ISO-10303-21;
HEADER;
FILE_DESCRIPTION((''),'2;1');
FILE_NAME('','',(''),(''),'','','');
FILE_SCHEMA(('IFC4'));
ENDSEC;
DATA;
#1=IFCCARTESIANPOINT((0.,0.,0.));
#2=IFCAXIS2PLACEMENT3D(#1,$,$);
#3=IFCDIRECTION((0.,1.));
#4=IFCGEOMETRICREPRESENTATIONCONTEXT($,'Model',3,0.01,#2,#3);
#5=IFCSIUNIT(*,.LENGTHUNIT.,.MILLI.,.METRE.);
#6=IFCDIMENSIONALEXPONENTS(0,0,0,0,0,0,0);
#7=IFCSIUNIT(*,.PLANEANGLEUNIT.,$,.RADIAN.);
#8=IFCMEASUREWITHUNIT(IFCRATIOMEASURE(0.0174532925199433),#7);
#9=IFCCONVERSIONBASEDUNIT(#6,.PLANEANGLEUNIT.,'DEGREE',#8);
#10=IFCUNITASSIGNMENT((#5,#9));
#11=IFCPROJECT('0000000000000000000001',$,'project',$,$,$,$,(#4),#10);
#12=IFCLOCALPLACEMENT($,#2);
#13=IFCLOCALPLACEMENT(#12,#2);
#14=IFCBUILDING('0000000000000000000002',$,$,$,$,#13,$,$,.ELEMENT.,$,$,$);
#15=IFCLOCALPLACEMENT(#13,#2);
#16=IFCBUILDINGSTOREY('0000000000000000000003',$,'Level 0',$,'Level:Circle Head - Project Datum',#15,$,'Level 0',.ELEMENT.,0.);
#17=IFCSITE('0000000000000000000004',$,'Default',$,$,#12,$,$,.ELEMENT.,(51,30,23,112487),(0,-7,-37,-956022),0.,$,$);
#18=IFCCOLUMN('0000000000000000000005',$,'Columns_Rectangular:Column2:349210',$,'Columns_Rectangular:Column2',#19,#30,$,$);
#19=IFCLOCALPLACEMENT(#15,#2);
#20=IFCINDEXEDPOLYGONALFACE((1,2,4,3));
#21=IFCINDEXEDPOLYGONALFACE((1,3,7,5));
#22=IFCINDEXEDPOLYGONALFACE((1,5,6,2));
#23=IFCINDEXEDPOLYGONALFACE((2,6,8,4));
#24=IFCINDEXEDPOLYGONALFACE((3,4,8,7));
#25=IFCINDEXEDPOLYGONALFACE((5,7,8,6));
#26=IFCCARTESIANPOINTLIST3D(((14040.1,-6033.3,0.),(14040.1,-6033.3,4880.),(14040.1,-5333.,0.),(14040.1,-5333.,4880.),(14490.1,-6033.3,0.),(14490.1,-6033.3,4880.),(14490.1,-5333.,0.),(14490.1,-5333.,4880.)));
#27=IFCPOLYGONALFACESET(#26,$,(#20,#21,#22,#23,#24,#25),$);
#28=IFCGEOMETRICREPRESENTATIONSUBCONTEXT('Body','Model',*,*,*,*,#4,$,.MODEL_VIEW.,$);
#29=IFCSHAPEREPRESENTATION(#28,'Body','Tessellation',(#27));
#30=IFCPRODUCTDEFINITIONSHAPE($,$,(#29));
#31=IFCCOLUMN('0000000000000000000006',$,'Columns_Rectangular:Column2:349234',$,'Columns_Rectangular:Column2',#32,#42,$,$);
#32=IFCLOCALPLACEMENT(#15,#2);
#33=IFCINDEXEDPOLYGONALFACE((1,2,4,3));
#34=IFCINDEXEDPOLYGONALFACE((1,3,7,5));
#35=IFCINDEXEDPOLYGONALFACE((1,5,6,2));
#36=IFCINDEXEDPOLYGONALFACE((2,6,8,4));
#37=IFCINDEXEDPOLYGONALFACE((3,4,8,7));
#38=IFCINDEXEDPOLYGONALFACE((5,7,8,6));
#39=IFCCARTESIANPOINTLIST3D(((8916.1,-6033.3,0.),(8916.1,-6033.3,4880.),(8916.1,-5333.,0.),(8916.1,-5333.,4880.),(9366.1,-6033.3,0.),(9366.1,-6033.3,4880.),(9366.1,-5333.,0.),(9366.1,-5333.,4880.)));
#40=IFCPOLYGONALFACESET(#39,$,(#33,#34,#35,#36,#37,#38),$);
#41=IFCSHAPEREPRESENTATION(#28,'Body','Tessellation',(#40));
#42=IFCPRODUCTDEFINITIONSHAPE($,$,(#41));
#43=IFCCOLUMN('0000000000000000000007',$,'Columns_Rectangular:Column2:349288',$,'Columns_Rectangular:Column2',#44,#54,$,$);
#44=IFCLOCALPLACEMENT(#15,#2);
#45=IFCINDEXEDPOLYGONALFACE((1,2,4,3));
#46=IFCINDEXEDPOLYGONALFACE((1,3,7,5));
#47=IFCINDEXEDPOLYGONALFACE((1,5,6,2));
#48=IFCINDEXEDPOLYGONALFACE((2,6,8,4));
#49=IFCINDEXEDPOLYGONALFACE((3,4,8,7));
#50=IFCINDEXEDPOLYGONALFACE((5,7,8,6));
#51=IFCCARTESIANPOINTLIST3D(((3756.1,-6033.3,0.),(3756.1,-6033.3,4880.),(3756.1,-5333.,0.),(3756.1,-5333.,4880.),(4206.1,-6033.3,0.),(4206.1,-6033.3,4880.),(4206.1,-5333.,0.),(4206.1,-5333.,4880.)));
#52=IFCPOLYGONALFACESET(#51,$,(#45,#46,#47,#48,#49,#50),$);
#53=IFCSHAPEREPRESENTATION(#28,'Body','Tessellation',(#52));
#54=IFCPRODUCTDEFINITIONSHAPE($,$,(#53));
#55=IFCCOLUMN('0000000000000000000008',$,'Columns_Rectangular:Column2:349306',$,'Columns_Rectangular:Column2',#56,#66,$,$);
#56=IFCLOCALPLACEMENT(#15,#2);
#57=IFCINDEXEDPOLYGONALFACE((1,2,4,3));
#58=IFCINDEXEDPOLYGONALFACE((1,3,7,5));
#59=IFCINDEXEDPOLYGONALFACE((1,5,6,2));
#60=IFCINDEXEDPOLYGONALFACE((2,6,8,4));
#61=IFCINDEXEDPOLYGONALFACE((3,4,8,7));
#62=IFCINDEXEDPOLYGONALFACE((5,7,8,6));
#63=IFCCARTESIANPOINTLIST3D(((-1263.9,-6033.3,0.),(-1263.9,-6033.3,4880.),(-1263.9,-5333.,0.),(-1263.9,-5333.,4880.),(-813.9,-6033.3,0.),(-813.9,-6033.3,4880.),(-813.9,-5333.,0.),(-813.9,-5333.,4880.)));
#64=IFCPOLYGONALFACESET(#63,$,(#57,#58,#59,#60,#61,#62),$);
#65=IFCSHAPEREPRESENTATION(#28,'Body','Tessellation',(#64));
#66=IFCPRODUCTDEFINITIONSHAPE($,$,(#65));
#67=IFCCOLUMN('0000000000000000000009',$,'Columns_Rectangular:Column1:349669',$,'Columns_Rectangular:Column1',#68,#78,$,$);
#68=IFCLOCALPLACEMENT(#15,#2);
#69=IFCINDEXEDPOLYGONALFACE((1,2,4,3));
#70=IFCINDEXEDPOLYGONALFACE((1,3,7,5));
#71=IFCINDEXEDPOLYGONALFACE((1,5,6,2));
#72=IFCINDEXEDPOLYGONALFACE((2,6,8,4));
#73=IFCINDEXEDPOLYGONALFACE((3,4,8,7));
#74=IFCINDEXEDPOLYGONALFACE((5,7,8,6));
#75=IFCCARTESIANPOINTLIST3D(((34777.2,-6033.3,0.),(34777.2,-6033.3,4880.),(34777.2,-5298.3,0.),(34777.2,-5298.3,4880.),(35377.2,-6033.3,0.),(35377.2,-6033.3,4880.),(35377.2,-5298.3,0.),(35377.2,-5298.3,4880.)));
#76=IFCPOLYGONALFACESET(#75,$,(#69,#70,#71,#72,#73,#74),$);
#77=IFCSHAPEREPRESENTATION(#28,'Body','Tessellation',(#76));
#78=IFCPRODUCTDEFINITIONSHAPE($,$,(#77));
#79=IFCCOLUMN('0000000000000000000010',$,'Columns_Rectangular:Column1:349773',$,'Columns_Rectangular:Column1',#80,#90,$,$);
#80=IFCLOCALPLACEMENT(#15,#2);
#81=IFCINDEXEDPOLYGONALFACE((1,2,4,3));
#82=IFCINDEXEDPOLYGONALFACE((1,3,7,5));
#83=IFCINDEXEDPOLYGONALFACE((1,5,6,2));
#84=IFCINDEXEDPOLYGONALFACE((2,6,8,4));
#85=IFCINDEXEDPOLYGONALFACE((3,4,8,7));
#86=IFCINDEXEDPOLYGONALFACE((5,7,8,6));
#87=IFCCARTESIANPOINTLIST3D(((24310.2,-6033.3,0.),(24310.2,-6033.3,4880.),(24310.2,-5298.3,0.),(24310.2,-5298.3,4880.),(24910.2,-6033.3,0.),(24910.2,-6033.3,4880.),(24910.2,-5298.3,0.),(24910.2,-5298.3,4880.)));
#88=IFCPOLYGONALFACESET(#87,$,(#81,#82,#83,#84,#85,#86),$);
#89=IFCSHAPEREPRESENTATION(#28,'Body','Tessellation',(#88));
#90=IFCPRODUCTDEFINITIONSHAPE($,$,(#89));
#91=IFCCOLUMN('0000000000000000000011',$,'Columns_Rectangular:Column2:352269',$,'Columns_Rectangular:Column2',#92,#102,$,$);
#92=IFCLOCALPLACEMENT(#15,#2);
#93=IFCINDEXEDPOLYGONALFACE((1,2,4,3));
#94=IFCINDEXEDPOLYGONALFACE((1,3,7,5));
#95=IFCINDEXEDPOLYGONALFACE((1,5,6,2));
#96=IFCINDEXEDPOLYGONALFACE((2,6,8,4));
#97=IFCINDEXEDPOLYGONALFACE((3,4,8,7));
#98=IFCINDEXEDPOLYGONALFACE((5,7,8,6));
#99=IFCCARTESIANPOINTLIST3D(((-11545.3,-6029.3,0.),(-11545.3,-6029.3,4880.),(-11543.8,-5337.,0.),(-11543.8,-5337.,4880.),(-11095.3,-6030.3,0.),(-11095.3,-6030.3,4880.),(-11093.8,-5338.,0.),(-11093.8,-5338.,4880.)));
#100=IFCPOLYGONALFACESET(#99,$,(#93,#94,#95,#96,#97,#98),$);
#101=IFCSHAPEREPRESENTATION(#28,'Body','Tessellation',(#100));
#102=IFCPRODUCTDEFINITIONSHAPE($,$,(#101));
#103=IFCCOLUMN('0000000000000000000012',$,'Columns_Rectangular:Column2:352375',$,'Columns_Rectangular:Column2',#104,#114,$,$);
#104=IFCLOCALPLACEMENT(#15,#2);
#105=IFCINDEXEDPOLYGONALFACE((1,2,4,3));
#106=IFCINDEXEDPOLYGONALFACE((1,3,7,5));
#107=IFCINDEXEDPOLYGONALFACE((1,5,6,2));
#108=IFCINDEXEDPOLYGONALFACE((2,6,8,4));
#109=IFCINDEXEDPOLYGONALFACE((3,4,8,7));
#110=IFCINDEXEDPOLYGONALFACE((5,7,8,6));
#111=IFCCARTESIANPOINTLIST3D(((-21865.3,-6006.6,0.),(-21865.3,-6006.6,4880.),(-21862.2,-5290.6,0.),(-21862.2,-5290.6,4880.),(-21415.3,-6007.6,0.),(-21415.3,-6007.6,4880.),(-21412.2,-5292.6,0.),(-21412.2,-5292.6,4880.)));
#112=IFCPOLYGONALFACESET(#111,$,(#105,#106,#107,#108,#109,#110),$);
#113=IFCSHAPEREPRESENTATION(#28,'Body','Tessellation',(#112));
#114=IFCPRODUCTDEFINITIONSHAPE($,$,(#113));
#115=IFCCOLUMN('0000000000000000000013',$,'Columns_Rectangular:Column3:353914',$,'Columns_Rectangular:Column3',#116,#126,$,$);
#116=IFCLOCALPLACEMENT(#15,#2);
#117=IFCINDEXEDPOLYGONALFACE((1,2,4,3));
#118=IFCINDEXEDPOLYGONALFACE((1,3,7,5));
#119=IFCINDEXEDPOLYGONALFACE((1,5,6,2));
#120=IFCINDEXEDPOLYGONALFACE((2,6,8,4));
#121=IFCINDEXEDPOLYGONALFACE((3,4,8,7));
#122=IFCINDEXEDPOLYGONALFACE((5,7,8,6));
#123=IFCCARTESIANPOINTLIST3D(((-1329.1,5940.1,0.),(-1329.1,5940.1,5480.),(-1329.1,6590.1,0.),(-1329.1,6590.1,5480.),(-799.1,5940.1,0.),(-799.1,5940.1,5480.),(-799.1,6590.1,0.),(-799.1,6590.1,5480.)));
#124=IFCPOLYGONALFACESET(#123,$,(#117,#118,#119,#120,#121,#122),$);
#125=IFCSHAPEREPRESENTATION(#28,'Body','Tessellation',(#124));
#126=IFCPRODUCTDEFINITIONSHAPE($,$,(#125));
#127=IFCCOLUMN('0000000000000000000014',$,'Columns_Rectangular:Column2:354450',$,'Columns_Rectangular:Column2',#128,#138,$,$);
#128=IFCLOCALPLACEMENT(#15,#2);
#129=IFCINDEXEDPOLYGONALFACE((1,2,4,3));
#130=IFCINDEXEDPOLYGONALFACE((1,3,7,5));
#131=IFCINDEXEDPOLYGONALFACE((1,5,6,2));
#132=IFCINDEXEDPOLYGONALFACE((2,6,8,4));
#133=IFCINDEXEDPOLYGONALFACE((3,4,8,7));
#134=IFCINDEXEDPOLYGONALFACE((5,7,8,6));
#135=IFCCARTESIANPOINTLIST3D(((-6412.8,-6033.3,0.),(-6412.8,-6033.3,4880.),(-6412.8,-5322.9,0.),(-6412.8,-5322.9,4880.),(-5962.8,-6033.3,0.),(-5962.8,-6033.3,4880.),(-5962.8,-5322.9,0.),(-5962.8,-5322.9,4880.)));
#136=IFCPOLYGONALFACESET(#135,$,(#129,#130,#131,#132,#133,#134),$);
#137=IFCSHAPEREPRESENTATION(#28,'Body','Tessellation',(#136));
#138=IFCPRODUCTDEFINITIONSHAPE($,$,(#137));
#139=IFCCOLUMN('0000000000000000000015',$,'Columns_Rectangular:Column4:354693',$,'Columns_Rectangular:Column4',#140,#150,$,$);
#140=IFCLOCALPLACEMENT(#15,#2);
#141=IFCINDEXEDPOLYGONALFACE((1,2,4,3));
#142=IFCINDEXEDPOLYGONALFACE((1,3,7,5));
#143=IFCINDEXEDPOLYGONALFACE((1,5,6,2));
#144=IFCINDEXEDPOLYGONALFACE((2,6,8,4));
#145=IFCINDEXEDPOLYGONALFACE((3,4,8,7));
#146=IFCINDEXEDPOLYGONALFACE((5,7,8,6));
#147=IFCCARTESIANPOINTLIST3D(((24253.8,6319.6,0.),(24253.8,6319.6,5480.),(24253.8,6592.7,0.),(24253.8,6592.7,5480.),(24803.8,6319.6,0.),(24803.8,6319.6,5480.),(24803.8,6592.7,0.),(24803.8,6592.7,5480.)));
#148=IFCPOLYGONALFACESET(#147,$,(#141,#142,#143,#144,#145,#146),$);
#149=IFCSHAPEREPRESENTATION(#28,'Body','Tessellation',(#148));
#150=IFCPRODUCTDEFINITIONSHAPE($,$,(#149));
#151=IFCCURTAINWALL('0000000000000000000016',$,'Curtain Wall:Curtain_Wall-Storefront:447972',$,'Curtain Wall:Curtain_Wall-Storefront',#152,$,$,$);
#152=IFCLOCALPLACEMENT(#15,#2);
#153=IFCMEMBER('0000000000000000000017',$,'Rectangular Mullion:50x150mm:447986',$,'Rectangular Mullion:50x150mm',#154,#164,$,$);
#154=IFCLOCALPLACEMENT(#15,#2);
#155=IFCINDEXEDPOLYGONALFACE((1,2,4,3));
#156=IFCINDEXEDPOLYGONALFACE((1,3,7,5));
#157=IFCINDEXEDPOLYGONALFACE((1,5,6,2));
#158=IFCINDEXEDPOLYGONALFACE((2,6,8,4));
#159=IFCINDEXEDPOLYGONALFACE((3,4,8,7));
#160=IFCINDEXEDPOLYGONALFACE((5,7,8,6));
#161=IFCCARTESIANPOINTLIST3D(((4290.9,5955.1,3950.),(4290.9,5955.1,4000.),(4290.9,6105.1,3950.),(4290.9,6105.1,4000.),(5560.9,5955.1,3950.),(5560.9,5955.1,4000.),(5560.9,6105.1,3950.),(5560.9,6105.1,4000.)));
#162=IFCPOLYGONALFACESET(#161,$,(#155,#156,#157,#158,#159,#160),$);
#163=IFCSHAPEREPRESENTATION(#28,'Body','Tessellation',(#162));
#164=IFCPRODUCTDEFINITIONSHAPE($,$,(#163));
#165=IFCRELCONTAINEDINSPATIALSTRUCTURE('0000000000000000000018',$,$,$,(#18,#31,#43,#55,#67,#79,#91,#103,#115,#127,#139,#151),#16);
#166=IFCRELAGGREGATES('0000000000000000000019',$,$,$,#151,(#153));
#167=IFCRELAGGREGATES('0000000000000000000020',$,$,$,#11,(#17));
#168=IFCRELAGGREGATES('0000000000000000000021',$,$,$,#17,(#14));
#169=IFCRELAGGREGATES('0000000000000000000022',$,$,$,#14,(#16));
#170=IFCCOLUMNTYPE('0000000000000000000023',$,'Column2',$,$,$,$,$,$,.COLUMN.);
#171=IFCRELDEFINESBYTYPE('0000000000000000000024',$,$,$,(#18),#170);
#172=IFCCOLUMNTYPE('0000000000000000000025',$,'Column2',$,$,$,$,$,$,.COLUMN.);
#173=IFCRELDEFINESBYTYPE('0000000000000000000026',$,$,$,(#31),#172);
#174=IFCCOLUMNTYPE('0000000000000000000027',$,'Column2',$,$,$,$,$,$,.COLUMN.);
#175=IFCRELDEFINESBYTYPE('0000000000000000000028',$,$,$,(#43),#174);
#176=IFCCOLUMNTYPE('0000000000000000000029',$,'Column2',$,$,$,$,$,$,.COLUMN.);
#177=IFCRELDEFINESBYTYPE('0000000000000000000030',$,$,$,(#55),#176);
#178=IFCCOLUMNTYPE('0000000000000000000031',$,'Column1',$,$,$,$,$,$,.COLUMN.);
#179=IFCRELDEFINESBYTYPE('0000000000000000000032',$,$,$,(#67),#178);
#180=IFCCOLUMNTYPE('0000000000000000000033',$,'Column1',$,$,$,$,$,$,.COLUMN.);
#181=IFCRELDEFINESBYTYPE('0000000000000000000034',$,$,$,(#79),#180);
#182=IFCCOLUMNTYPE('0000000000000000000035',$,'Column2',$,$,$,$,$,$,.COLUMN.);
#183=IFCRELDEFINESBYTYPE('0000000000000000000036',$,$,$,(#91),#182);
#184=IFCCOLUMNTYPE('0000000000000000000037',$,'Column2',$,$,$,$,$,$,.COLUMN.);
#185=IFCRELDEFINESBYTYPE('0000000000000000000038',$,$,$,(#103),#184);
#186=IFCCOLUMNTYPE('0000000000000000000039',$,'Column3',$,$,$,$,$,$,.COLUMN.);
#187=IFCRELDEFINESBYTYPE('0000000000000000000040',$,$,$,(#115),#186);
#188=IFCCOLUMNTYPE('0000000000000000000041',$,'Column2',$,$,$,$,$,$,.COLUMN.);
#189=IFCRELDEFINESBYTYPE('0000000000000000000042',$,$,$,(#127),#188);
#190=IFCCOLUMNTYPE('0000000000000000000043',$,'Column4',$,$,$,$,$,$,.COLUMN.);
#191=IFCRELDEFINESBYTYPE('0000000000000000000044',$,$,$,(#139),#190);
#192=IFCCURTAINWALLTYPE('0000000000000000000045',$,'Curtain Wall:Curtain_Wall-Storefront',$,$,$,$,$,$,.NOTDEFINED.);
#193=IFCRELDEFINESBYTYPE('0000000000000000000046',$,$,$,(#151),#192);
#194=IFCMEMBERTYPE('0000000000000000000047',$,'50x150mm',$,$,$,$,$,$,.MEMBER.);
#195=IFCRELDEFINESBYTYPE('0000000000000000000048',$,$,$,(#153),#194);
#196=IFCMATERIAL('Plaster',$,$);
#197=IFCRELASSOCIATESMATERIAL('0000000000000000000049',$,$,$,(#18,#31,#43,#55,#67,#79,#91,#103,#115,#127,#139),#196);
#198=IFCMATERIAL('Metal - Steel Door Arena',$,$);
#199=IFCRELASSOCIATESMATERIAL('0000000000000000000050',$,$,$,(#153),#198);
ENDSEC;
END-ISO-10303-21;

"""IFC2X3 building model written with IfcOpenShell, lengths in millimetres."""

from ifc_helpers import new_model, entity, si_unit, converted_unit, direction, frame, frame_2d, origin, origin_2d_with_axis, place, context, subcontext, project, spatial, polyline, rectangle, outline, extrude, source, transform, mapped, material, type_object, type_shapes, element, aggregate, save


model = new_model("IFC2X3")

# Units and contexts
model_context = context("Model", 3, precision=0.01, world=origin(), true_north=direction((0.0, 1.0)))
body_context = subcontext(model_context, "Body", "Model", "MODEL_VIEW")
ifc_project = project(units=[si_unit("LENGTHUNIT", "METRE", prefix="MILLI"), converted_unit("PLANEANGLEUNIT", "DEGREE", entity("IfcRatioMeasure", 0.0174532925199433), si_unit("PLANEANGLEUNIT", "RADIAN"), dimensions=[0, 0, 0, 0, 0, 0, 0])], contexts=[model_context])

# Site, building, storey
site_placement = place(None, origin())
site = spatial("IfcSite", under=ifc_project, at=site_placement, Name="Default", CompositionType="ELEMENT", RefLatitude=(51, 30, 23, 112487), RefLongitude=(0, -7, -37, -956022), RefElevation=0.0)
building_placement = place(site_placement, origin())
building = spatial("IfcBuilding", under=site, at=building_placement, CompositionType="ELEMENT")
storey_placement = place(building_placement, origin())
storey = spatial("IfcBuildingStorey", under=building, at=storey_placement, Name="Level 0", ObjectType="Level:Circle Head - Project Datum", LongName="Level 0", CompositionType="ELEMENT", Elevation=0.0)

# Columns
ifc_material_1 = material(Name="Plaster")
column_type_1 = type_object("IfcColumnType", Name="Column2", PredefinedType="COLUMN")
shared_shape_1 = source(origin(), body_context, "Body", "SweptSolid", [
    extrude(rectangle(XDim=700.3, YDim=450.0, at=frame_2d((0.0, 0.0), x_axis=(1.0, 0.0))), frame((14265.1, -5683.1, 0.0), z_axis=(0.0, 0.0, 1.0), x_axis=(0.0, -1.0, 0.0)), (0.0, 0.0, 1.0), 4880.0),
])
type_shapes(column_type_1, [shared_shape_1])
column_1_placement = place(storey_placement, origin())
element("IfcColumn", 1, at=column_1_placement, inside=storey, type_object=column_type_1, material=ifc_material_1, Name="Columns_Rectangular:Column2:349210", ObjectType="Columns_Rectangular:Column2", context=body_context, shape_type="MappedRepresentation", body=[
    mapped(shared_shape_1, transform((0.0, 0.0, 0.0), scale=1.0)),
])
column_type_2 = type_object("IfcColumnType", Name="Column2", PredefinedType="COLUMN")
shared_shape_2 = source(origin(), body_context, "Body", "SweptSolid", [
    extrude(rectangle(XDim=700.3, YDim=450.0, at=frame_2d((0.0, 0.0), x_axis=(1.0, 0.0))), frame((9141.1, -5683.1, 0.0), z_axis=(0.0, 0.0, 1.0), x_axis=(0.0, -1.0, 0.0)), (0.0, 0.0, 1.0), 4880.0),
])
type_shapes(column_type_2, [shared_shape_2])
column_2_placement = place(storey_placement, origin())
element("IfcColumn", 2, at=column_2_placement, inside=storey, type_object=column_type_2, material=ifc_material_1, Name="Columns_Rectangular:Column2:349234", ObjectType="Columns_Rectangular:Column2", context=body_context, shape_type="MappedRepresentation", body=[
    mapped(shared_shape_2, transform((0.0, 0.0, 0.0), scale=1.0)),
])
column_type_3 = type_object("IfcColumnType", Name="Column2", PredefinedType="COLUMN")
shared_shape_3 = source(origin(), body_context, "Body", "SweptSolid", [
    extrude(rectangle(XDim=700.3, YDim=450.0, at=frame_2d((0.0, 0.0), x_axis=(1.0, 0.0))), frame((3981.1, -5683.1, 0.0), z_axis=(0.0, 0.0, 1.0), x_axis=(0.0, -1.0, 0.0)), (0.0, 0.0, 1.0), 4880.0),
])
type_shapes(column_type_3, [shared_shape_3])
column_3_placement = place(storey_placement, origin())
element("IfcColumn", 3, at=column_3_placement, inside=storey, type_object=column_type_3, material=ifc_material_1, Name="Columns_Rectangular:Column2:349288", ObjectType="Columns_Rectangular:Column2", context=body_context, shape_type="MappedRepresentation", body=[
    mapped(shared_shape_3, transform((0.0, 0.0, 0.0), scale=1.0)),
])
column_type_4 = type_object("IfcColumnType", Name="Column2", PredefinedType="COLUMN")
shared_shape_4 = source(origin(), body_context, "Body", "SweptSolid", [
    extrude(rectangle(XDim=700.3, YDim=450.0, at=frame_2d((0.0, 0.0), x_axis=(1.0, 0.0))), frame((-1038.9, -5683.1, 0.0), z_axis=(0.0, 0.0, 1.0), x_axis=(0.0, -1.0, 0.0)), (0.0, 0.0, 1.0), 4880.0),
])
type_shapes(column_type_4, [shared_shape_4])
column_4_placement = place(storey_placement, origin())
element("IfcColumn", 4, at=column_4_placement, inside=storey, type_object=column_type_4, material=ifc_material_1, Name="Columns_Rectangular:Column2:349306", ObjectType="Columns_Rectangular:Column2", context=body_context, shape_type="MappedRepresentation", body=[
    mapped(shared_shape_4, transform((0.0, 0.0, 0.0), scale=1.0)),
])
column_type_5 = type_object("IfcColumnType", Name="Column1", PredefinedType="COLUMN")
shared_shape_5 = source(origin(), body_context, "Body", "SweptSolid", [
    extrude(rectangle(XDim=735.0, YDim=600.0, at=frame_2d((0.0, 0.0), x_axis=(1.0, 0.0))), frame((35077.2, -5665.8, 0.0), z_axis=(0.0, 0.0, 1.0), x_axis=(0.0, -1.0, 0.0)), (0.0, 0.0, 1.0), 4880.0),
])
type_shapes(column_type_5, [shared_shape_5])
column_5_placement = place(storey_placement, origin())
element("IfcColumn", 5, at=column_5_placement, inside=storey, type_object=column_type_5, material=ifc_material_1, Name="Columns_Rectangular:Column1:349669", ObjectType="Columns_Rectangular:Column1", context=body_context, shape_type="MappedRepresentation", body=[
    mapped(shared_shape_5, transform((0.0, 0.0, 0.0), scale=1.0)),
])
column_type_6 = type_object("IfcColumnType", Name="Column1", PredefinedType="COLUMN")
shared_shape_6 = source(origin(), body_context, "Body", "SweptSolid", [
    extrude(rectangle(XDim=735.0, YDim=600.0, at=origin_2d_with_axis()), frame((24610.2, -5665.8, 0.0), z_axis=(0.0, 0.0, 1.0), x_axis=(0.0, -1.0, 0.0)), (0.0, 0.0, 1.0), 4880.0),
])
type_shapes(column_type_6, [shared_shape_6])
column_6_placement = place(storey_placement, origin())
element("IfcColumn", 6, at=column_6_placement, inside=storey, type_object=column_type_6, material=ifc_material_1, Name="Columns_Rectangular:Column1:349773", ObjectType="Columns_Rectangular:Column1", context=body_context, shape_type="MappedRepresentation", body=[
    mapped(shared_shape_6, transform((0.0, 0.0, 0.0), scale=1.0)),
])
column_type_7 = type_object("IfcColumnType", Name="Column2", PredefinedType="COLUMN")
shared_shape_7 = source(origin(), body_context, "Body", "SweptSolid", [
    extrude(outline(polyline([(-225.0, -346.1), (225.0, -346.1), (225.0, 346.1), (-225.0, 346.1), (-225.0, -346.1)])), frame((-11319.5, -5683.6, 0.0), z_axis=(0.0, 0.0, 1.0), x_axis=(-0.999998, 0.002173, 0.0)), (0.0, 0.0, 1.0), 4880.0),
])
type_shapes(column_type_7, [shared_shape_7])
column_7_placement = place(storey_placement, origin())
element("IfcColumn", 7, at=column_7_placement, inside=storey, type_object=column_type_7, material=ifc_material_1, Name="Columns_Rectangular:Column2:352269", ObjectType="Columns_Rectangular:Column2", context=body_context, shape_type="MappedRepresentation", body=[
    mapped(shared_shape_7, transform((0.0, 0.0, 0.0), scale=1.0)),
])
column_type_8 = type_object("IfcColumnType", Name="Column2", PredefinedType="COLUMN")
shared_shape_8 = source(origin(), body_context, "Body", "SweptSolid", [
    extrude(outline(polyline([(-225.0, -357.8), (225.0, -357.8), (225.0, 358.3), (-225.0, 357.3), (-225.0, -357.8)])), frame((-21638.7, -5649.3, 0.0), z_axis=(0.0, 0.0, 1.0), x_axis=(-0.99999, 0.004372, 0.0)), (0.0, 0.0, 1.0), 4880.0),
])
type_shapes(column_type_8, [shared_shape_8])
column_8_placement = place(storey_placement, origin())
element("IfcColumn", 8, at=column_8_placement, inside=storey, type_object=column_type_8, material=ifc_material_1, Name="Columns_Rectangular:Column2:352375", ObjectType="Columns_Rectangular:Column2", context=body_context, shape_type="MappedRepresentation", body=[
    mapped(shared_shape_8, transform((0.0, 0.0, 0.0), scale=1.0)),
])
column_type_9 = type_object("IfcColumnType", Name="Column3", PredefinedType="COLUMN")
shared_shape_9 = source(origin(), body_context, "Body", "SweptSolid", [
    extrude(rectangle(XDim=650.0, YDim=530.0, at=frame_2d((0.0, 0.0), x_axis=(1.0, 0.0))), frame((-1064.1, 6265.1, 0.0), z_axis=(0.0, 0.0, 1.0), x_axis=(0.0, -1.0, 0.0)), (0.0, 0.0, 1.0), 5480.0),
])
type_shapes(column_type_9, [shared_shape_9])
column_9_placement = place(storey_placement, origin())
element("IfcColumn", 9, at=column_9_placement, inside=storey, type_object=column_type_9, material=ifc_material_1, Name="Columns_Rectangular:Column3:353914", ObjectType="Columns_Rectangular:Column3", context=body_context, shape_type="MappedRepresentation", body=[
    mapped(shared_shape_9, transform((0.0, 0.0, 0.0), scale=1.0)),
])
column_type_10 = type_object("IfcColumnType", Name="Column2", PredefinedType="COLUMN")
shared_shape_10 = source(origin(), body_context, "Body", "SweptSolid", [
    extrude(rectangle(XDim=710.3, YDim=450.0, at=frame_2d((0.0, 0.0), x_axis=(1.0, 0.0))), frame((-6187.8, -5678.1, 0.0), z_axis=(0.0, 0.0, 1.0), x_axis=(0.0, -1.0, 0.0)), (0.0, 0.0, 1.0), 4880.0),
])
type_shapes(column_type_10, [shared_shape_10])
column_10_placement = place(storey_placement, origin())
element("IfcColumn", 10, at=column_10_placement, inside=storey, type_object=column_type_10, material=ifc_material_1, Name="Columns_Rectangular:Column2:354450", ObjectType="Columns_Rectangular:Column2", context=body_context, shape_type="MappedRepresentation", body=[
    mapped(shared_shape_10, transform((0.0, 0.0, 0.0), scale=1.0)),
])
column_type_11 = type_object("IfcColumnType", Name="Column4", PredefinedType="COLUMN")
shared_shape_11 = source(origin(), body_context, "Body", "SweptSolid", [
    extrude(rectangle(XDim=273.1, YDim=550.0, at=frame_2d((0.0, 0.0), x_axis=(1.0, 0.0))), frame((24528.8, 6456.2, 0.0), z_axis=(0.0, 0.0, 1.0), x_axis=(0.0, -1.0, 0.0)), (0.0, 0.0, 1.0), 5480.0),
])
type_shapes(column_type_11, [shared_shape_11])
column_11_placement = place(storey_placement, origin())
element("IfcColumn", 11, at=column_11_placement, inside=storey, type_object=column_type_11, material=ifc_material_1, Name="Columns_Rectangular:Column4:354693", ObjectType="Columns_Rectangular:Column4", context=body_context, shape_type="MappedRepresentation", body=[
    mapped(shared_shape_11, transform((0.0, 0.0, 0.0), scale=1.0)),
])

# Curtain wall, member
curtain_wall_type = type_object("IfcCurtainWallType", Name="Curtain Wall:Curtain_Wall-Storefront", PredefinedType="NOTDEFINED")
curtain_wall_placement = place(storey_placement, origin())
curtain_wall = element("IfcCurtainWall", 12, at=curtain_wall_placement, inside=storey, type_object=curtain_wall_type, Name="Curtain Wall:Curtain_Wall-Storefront:447972", ObjectType="Curtain Wall:Curtain_Wall-Storefront")
ifc_material_2 = material(Name="Metal - Steel Door Arena")
member_type_1 = type_object("IfcMemberType", Name="50x150mm", PredefinedType="MEMBER")
shared_shape_12 = source(origin(), body_context, "Body", "SweptSolid", [
    extrude(rectangle(XDim=150.0, YDim=50.0, at=origin_2d_with_axis()), frame((-25.0, 0.0, -1270.0), z_axis=(0.0, 0.0, 1.0), x_axis=(0.0, -1.0, 0.0)), (0.0, 0.0, 1.0), 1270.0),
])
type_shapes(member_type_1, [shared_shape_12])
member_1_placement = place(storey_placement, frame((4290.9, 6030.1, 4000.0), z_axis=(-1.0, 0.0, 0.0), x_axis=(0.0, 0.0, 1.0)))
member_1 = element("IfcMember", 13, at=member_1_placement, type_object=member_type_1, material=ifc_material_2, Name="Rectangular Mullion:50x150mm:447986", ObjectType="Rectangular Mullion:50x150mm", context=body_context, shape_type="MappedRepresentation", body=[
    mapped(shared_shape_12, transform((0.0, 0.0, 0.0), scale=1.0)),
])
aggregate(curtain_wall, [member_1])

save(model, "model.ifc")
